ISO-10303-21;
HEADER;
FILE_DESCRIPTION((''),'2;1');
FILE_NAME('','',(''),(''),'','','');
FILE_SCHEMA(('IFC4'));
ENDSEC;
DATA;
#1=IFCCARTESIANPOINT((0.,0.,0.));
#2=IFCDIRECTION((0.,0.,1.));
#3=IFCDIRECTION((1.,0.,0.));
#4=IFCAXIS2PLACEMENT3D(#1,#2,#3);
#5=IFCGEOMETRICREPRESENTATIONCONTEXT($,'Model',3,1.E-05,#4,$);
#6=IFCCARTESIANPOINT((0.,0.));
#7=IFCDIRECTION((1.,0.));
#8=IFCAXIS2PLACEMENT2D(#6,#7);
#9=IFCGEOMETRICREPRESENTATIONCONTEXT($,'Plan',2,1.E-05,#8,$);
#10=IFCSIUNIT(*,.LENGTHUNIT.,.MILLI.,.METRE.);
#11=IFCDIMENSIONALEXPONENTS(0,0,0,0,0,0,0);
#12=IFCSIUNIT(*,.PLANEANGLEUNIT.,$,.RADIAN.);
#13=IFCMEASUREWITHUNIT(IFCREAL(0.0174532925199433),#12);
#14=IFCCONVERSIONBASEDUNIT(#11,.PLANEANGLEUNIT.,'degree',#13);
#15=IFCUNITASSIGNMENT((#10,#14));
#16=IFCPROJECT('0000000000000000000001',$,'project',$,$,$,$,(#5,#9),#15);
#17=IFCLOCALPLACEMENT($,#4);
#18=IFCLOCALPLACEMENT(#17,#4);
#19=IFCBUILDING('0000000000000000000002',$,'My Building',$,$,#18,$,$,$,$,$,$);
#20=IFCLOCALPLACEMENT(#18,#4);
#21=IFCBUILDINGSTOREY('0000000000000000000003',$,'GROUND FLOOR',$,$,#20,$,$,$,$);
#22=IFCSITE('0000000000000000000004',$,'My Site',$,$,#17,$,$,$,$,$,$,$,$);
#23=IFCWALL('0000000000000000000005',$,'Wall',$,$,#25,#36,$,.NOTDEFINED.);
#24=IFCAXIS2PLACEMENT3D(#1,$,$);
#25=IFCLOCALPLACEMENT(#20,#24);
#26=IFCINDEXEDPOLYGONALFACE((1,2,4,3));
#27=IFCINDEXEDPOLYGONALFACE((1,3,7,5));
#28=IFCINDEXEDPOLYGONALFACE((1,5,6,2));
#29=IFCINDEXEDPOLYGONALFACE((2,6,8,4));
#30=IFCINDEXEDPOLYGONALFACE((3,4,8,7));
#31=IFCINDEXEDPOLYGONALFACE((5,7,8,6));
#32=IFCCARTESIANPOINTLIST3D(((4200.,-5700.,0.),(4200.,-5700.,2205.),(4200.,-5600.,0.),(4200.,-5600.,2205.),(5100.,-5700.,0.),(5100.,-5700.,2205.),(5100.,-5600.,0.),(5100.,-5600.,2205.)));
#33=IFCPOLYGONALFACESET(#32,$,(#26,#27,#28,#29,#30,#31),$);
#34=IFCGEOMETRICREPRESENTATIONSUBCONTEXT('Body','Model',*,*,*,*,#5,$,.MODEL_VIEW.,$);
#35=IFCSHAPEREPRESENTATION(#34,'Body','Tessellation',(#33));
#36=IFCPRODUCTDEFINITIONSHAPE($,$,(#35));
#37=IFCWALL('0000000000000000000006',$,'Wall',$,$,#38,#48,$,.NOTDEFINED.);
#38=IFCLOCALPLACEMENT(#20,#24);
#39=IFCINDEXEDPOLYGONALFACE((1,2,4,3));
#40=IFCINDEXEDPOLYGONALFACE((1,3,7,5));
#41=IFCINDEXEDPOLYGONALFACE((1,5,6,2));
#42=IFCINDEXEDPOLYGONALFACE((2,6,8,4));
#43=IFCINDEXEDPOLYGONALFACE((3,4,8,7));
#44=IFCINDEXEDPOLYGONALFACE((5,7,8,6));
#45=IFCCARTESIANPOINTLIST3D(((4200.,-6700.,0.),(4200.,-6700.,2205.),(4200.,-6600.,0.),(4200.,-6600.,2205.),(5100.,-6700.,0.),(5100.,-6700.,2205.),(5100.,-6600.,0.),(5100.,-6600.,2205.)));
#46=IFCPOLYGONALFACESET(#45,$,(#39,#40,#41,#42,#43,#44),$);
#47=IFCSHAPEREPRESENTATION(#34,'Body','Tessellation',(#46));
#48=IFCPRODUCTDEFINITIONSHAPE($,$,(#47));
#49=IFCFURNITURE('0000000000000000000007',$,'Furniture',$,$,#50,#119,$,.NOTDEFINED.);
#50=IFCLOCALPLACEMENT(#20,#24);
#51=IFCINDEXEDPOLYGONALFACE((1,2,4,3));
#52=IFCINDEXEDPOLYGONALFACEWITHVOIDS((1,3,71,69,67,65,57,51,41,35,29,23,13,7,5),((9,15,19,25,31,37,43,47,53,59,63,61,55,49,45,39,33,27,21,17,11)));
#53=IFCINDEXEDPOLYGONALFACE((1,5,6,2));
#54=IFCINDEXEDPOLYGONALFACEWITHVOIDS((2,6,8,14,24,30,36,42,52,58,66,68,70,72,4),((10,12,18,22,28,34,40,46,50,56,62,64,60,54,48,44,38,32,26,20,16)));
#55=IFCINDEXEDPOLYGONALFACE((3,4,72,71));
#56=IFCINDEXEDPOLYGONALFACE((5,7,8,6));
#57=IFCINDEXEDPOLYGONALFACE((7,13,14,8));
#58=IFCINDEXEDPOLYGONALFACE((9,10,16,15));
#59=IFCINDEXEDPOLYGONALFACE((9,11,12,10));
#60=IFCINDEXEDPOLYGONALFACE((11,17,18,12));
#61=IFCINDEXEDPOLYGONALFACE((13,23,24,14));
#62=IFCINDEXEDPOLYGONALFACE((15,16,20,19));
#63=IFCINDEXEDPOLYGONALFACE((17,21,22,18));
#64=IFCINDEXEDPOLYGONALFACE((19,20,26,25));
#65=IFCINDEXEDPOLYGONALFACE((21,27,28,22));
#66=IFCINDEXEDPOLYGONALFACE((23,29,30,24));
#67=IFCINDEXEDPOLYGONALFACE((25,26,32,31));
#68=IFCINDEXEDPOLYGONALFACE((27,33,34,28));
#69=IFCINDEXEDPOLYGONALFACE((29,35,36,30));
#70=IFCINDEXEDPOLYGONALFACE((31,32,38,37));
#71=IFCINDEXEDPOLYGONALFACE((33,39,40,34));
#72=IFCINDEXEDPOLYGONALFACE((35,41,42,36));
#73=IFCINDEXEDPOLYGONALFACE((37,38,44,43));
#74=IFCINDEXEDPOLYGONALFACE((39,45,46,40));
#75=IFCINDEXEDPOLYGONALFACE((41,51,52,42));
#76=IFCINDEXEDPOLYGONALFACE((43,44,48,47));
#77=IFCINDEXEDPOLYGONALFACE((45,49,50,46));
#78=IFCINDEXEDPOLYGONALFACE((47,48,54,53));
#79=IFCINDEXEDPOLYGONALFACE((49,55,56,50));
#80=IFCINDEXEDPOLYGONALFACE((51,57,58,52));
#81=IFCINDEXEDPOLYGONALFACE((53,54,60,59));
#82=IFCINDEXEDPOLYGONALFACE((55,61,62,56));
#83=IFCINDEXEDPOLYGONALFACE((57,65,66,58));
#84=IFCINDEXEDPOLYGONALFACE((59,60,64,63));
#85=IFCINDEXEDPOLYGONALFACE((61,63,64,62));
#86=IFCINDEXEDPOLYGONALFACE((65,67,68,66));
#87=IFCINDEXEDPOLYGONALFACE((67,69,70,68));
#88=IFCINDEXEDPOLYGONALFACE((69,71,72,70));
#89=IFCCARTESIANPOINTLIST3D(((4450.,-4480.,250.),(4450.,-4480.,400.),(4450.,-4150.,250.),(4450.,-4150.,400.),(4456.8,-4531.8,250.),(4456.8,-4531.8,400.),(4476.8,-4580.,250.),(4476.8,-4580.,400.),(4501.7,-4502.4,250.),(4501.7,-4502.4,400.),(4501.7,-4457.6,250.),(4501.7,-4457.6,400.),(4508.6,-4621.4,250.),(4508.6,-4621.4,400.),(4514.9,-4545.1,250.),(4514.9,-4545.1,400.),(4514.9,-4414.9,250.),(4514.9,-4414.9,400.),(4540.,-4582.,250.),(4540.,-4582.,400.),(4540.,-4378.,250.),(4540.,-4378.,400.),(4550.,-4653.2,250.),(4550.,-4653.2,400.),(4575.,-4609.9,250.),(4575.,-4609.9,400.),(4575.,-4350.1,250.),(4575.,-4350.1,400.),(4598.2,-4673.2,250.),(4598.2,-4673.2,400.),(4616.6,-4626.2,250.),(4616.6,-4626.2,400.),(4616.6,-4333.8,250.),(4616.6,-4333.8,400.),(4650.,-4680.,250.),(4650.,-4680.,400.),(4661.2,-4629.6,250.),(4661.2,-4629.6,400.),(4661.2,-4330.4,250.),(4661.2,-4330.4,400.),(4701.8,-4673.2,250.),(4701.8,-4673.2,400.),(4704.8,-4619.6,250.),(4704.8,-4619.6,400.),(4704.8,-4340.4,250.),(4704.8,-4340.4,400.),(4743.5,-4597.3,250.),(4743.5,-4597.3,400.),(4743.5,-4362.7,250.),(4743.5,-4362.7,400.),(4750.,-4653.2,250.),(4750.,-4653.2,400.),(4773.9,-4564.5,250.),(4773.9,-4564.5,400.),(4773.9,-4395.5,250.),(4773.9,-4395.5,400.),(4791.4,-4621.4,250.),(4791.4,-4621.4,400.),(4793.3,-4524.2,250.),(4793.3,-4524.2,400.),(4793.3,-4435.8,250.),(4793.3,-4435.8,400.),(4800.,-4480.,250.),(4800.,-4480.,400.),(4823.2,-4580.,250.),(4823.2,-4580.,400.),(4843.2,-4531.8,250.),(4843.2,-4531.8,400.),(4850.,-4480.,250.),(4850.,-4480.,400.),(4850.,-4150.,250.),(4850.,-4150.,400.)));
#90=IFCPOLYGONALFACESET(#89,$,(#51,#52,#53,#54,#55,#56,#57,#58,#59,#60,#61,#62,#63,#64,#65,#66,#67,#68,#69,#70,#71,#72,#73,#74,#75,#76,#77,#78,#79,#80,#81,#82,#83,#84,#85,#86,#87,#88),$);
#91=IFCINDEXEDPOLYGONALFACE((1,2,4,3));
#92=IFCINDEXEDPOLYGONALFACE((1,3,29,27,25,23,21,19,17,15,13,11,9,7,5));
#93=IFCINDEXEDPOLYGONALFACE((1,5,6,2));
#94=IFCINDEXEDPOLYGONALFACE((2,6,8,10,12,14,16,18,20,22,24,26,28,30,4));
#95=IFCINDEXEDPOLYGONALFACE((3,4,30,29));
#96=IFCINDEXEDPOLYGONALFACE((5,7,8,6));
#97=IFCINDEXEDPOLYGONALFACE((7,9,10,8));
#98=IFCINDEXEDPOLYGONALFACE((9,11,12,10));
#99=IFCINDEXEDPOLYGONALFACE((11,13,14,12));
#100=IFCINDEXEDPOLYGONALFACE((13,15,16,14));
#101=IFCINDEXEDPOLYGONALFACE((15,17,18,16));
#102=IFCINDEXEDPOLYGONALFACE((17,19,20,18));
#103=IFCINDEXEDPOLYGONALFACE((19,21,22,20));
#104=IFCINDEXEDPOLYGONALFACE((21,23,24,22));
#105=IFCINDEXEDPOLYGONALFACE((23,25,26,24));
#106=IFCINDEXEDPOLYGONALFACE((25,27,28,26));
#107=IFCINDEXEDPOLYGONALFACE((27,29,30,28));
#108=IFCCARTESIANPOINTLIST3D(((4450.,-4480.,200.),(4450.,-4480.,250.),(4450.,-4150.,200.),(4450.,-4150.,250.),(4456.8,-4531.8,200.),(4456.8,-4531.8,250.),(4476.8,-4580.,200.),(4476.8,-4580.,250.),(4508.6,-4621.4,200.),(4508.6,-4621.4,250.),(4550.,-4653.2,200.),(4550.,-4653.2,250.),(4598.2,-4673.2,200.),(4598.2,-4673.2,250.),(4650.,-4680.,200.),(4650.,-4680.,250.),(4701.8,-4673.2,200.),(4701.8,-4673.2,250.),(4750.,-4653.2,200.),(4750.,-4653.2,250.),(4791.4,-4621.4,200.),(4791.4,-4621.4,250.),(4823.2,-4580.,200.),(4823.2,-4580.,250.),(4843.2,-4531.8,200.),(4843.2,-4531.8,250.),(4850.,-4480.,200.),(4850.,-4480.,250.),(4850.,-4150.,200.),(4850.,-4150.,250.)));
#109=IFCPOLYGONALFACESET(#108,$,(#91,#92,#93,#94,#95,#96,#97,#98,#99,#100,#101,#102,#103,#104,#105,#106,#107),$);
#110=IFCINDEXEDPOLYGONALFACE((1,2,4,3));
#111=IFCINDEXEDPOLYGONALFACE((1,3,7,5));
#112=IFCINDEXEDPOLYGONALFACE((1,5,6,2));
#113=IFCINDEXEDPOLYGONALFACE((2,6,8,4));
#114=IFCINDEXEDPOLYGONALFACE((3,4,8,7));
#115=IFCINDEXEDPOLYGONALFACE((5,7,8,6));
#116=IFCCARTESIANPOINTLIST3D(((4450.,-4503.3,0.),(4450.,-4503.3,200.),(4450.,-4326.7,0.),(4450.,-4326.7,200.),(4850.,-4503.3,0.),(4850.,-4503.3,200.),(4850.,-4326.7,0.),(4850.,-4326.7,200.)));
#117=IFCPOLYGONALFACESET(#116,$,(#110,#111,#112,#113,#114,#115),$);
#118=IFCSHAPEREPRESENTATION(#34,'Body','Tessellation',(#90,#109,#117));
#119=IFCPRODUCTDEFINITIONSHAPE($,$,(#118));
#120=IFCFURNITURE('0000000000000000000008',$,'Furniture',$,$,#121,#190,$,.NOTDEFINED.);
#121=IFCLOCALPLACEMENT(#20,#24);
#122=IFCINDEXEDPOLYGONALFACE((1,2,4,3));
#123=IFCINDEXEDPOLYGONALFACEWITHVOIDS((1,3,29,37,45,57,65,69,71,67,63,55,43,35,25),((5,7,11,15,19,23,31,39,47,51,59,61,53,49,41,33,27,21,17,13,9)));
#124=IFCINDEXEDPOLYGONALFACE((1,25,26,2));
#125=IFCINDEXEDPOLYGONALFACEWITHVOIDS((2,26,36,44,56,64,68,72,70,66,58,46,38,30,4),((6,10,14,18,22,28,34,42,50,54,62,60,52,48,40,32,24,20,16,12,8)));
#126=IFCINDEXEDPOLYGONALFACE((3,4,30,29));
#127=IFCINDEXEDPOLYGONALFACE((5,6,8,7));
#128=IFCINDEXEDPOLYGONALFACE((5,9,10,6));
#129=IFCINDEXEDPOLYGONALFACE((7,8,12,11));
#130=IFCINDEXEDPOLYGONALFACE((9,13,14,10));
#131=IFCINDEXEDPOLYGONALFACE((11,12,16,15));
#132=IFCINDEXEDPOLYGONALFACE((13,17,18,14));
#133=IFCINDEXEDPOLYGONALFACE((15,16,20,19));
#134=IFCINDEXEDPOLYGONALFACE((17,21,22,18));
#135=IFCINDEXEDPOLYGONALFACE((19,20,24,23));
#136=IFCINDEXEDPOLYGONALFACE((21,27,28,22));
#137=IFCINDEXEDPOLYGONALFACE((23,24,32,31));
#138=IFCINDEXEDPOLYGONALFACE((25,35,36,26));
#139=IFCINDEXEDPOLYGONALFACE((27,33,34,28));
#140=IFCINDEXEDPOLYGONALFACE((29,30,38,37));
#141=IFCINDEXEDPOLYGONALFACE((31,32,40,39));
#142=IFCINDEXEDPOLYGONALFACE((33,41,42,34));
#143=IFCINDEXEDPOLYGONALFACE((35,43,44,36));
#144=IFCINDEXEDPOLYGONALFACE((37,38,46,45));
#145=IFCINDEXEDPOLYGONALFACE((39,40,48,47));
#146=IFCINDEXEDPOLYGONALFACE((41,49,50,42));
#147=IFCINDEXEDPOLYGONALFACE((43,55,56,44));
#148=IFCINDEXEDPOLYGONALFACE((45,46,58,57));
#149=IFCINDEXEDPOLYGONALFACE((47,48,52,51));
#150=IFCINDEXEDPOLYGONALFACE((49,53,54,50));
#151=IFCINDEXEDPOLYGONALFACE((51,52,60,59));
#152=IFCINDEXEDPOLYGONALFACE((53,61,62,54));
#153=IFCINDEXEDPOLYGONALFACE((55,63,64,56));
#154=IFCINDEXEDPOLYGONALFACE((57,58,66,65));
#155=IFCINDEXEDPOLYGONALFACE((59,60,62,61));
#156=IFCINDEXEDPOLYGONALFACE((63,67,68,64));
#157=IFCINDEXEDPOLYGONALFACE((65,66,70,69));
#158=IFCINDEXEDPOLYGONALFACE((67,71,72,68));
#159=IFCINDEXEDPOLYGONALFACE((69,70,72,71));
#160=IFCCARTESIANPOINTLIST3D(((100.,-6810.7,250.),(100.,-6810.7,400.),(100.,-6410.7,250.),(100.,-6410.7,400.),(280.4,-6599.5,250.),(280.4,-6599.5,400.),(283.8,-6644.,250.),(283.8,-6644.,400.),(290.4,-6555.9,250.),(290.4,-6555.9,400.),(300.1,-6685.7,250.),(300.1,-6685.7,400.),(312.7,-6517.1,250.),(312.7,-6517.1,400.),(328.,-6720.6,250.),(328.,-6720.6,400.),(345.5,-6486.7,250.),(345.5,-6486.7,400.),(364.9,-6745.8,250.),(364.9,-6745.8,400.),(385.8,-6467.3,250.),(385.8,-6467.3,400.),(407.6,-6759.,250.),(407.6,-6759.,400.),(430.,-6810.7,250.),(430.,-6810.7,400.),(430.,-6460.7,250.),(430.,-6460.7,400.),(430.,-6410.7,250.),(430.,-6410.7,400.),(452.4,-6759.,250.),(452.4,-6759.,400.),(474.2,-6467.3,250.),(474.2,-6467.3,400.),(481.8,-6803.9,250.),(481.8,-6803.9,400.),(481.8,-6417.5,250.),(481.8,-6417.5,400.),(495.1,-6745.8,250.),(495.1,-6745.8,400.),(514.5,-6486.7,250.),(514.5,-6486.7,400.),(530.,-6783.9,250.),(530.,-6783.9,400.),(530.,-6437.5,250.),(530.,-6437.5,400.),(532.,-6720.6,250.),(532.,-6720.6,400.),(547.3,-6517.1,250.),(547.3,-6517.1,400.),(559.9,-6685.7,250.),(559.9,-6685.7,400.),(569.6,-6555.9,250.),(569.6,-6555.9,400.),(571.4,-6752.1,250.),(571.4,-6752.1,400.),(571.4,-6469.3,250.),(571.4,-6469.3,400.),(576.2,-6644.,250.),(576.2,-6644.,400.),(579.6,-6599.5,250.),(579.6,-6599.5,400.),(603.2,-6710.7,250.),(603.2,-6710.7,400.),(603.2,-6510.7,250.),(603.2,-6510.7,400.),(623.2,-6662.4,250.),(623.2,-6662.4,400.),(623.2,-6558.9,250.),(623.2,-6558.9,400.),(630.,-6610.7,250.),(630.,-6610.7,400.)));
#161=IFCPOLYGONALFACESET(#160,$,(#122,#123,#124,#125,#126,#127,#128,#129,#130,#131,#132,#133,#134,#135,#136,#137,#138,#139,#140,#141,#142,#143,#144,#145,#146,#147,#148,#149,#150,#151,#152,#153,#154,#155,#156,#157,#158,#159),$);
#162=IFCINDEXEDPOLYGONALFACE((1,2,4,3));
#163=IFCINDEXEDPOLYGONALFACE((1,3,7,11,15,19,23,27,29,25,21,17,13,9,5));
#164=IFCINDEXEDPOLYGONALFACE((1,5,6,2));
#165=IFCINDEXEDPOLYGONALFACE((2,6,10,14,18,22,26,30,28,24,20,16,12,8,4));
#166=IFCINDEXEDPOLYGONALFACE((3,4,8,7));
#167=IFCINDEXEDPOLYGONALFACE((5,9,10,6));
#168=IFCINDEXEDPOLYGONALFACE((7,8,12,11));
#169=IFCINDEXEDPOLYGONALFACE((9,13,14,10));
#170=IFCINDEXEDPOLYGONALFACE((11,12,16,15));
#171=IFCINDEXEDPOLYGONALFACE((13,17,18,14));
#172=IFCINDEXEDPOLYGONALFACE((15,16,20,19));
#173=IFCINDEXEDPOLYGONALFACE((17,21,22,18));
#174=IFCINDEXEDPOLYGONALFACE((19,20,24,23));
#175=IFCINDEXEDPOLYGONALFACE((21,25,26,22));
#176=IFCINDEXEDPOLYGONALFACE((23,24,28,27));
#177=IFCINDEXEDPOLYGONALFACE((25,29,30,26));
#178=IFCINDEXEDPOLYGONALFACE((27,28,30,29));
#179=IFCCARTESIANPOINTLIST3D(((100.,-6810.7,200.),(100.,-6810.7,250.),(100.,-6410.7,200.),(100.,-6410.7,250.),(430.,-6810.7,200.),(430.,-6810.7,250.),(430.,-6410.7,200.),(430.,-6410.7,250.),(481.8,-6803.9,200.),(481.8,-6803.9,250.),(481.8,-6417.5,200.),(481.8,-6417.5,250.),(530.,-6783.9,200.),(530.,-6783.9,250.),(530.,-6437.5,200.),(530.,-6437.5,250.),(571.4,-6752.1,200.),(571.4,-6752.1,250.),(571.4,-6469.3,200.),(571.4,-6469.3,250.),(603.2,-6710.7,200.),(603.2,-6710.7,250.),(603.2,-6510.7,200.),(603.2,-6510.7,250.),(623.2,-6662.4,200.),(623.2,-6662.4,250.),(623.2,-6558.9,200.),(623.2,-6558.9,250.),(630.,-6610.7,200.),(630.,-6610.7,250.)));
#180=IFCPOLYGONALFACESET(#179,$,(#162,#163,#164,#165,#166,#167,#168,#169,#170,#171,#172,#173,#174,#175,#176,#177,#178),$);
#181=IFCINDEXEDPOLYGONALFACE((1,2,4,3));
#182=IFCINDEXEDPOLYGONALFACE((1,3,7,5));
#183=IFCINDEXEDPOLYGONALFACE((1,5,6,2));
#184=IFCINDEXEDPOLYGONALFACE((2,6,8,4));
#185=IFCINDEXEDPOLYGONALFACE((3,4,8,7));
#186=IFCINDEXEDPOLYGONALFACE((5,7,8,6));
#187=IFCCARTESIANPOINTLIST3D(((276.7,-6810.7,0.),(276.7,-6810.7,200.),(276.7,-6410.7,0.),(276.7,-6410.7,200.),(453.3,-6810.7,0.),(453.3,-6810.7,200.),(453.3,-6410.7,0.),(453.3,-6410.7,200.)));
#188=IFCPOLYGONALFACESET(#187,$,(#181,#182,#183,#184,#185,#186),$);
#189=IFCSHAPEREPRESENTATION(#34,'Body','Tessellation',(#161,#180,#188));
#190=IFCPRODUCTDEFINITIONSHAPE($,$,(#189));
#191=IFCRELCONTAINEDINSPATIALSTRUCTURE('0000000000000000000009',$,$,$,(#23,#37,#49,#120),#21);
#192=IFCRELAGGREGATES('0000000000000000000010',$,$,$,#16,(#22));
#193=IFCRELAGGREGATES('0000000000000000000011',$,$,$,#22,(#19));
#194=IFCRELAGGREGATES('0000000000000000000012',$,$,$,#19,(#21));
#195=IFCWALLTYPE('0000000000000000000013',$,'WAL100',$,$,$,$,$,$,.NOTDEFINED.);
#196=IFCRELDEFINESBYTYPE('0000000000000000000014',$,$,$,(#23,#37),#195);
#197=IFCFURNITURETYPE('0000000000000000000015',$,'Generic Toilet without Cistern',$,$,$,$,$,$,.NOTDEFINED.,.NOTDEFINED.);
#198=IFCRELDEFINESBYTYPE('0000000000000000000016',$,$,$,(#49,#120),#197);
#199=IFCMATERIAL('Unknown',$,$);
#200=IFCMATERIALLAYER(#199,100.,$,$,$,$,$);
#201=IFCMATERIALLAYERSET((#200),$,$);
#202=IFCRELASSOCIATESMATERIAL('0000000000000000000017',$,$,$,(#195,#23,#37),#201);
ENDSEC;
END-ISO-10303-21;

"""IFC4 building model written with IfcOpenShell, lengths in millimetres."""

from ifc_helpers import new_model, entity, si_unit, converted_unit, frame, frame_2d, origin_with_axes, origin_2d_with_axis, place, context, subcontext, project, spatial, line, arc, indexed_curve, circle_curve, outline, extrude, source, transform, mapped, material, layer, layer_set, layer_usage, type_object, type_shapes, element, save


model = new_model("IFC4")

# Units and contexts
model_context = context("Model", 3, precision=1e-05, world=origin_with_axes())
plan_context = context("Plan", 2, precision=1e-05, world=origin_2d_with_axis())
body_context = subcontext(model_context, "Body", "Model", "MODEL_VIEW")
ifc_project = project(units=[si_unit("LENGTHUNIT", "METRE", prefix="MILLI"), converted_unit("PLANEANGLEUNIT", "degree", entity("IfcReal", 0.0174532925199433), si_unit("PLANEANGLEUNIT", "RADIAN"), dimensions=[0, 0, 0, 0, 0, 0, 0])], contexts=[model_context, plan_context])

# Site, building, storey
site_placement = place(None, origin_with_axes())
site = spatial("IfcSite", under=ifc_project, at=site_placement, Name="My Site")
building_placement = place(site_placement, origin_with_axes())
building = spatial("IfcBuilding", under=site, at=building_placement, Name="My Building")
storey_placement = place(building_placement, origin_with_axes())
storey = spatial("IfcBuildingStorey", under=building, at=storey_placement, Name="GROUND FLOOR")

# Shared definitions
ifc_material = material(Name="Unknown")

# Walls
ifc_layer_1 = layer(ifc_material, 100.0)
ifc_layer_set_1 = layer_set([ifc_layer_1])
wall_type = type_object("IfcWallType", Name="WAL100", PredefinedType="NOTDEFINED", material=ifc_layer_set_1)
ifc_layer_usage_1 = layer_usage(ifc_layer_set_1, "AXIS2", "POSITIVE", 0.0)
wall_1_placement = place(storey_placement, frame((5100.0, -5600.0, 0.0), z_axis=(0.0, 0.0, 1.0), x_axis=(-1.0, 0.0, 0.0)))
element("IfcWall", 1, at=wall_1_placement, inside=storey, type_object=wall_type, material=ifc_layer_usage_1, Name="Wall", PredefinedType="NOTDEFINED", context=body_context, shape_type="SweptSolid", body=[
    extrude(outline(indexed_curve([(0.0, 0.0), (0.0, 100.0), (900.0, 100.0), (900.0, 0.0), (0.0, 0.0)], self_intersect=False)), origin_with_axes(), (0.0, 0.0, 1.0), 2205.0),
])
ifc_layer_usage_2 = layer_usage(ifc_layer_set_1, "AXIS2", "POSITIVE", 0.0)
wall_2_placement = place(storey_placement, frame((5100.0, -6600.0, 0.0), z_axis=(0.0, 0.0, 1.0), x_axis=(-1.0, 0.0, 0.0)))
element("IfcWall", 2, at=wall_2_placement, inside=storey, type_object=wall_type, material=ifc_layer_usage_2, Name="Wall", PredefinedType="NOTDEFINED", context=body_context, shape_type="SweptSolid", body=[
    extrude(outline(indexed_curve([(0.0, 0.0), (0.0, 100.0), (900.0, 100.0), (900.0, 0.0), (0.0, 0.0)], self_intersect=False)), origin_with_axes(), (0.0, 0.0, 1.0), 2205.0),
])

# Furniture
furniture_type_1 = type_object("IfcFurnitureType", Name="Generic Toilet without Cistern", AssemblyPlace="NOTDEFINED", PredefinedType="NOTDEFINED")
shared_shape_1 = source(origin_with_axes(), body_context, "Body", "SweptSolid", [
    extrude(outline(indexed_curve([(-200.0, 0.0, 0.0), (-200.0, -330.0, 0.0), (-141.4, -471.4, 0.0), (0.0, -530.0, 0.0), (141.4, -471.4, 0.0), (200.0, -330.0, 0.0), (200.0, 0.0, 0.0)], segments=[line(1, 2), arc(2, 3, 4), arc(4, 5, 6), line(6, 7), line(1, 7)]), holes=[circle_curve(frame_2d((0.0, -330.0)), 150.0)]), frame((0.0, 0.0, 250.0), z_axis=(0.0, 0.0, 1.0), x_axis=(1.0, 0.0, 0.0)), (0.0, 0.0, 1.0), 150.0),
    extrude(outline(indexed_curve([(-200.0, 0.0, 0.0), (-200.0, -330.0, 0.0), (-141.4, -471.4, 0.0), (0.0, -530.0, 0.0), (141.4, -471.4, 0.0), (200.0, -330.0, 0.0), (200.0, 0.0, 0.0)], segments=[line(1, 2), arc(2, 3, 4), arc(4, 5, 6), line(6, 7), line(1, 7)])), frame((0.0, 0.0, 200.0), z_axis=(0.0, 0.0, 1.0), x_axis=(1.0, 0.0, 0.0)), (0.0, 0.0, 1.0), 50.0),
    extrude(outline(indexed_curve([(-200.0, -176.7, 0.0), (-200.0, -353.3, 0.0), (200.0, -353.3, 0.0), (200.0, -176.7, 0.0)], segments=[line(1, 2), line(2, 3), line(3, 4), line(4, 1)])), origin_with_axes(), (0.0, 0.0, 1.0), 200.0),
])
type_shapes(furniture_type_1, [shared_shape_1])
for number, where, z_axis, x_axis, name in (
    (3, (4650.0, -4150.0, 0.0), (0.0, 0.0, 1.0), (1.0, 0.0, 0.0), "Furniture"),
    (4, (100.0, -6610.7, 0.0), (0.0, 0.0, 1.0), (0.0, 1.0, 0.0), "Furniture"),
):
    element("IfcFurniture", number, at=place(storey_placement, frame(where, z_axis=z_axis, x_axis=x_axis)), inside=storey, type_object=furniture_type_1, Name=name, PredefinedType="NOTDEFINED", context=body_context, shape_type="MappedRepresentation", body=[
        mapped(shared_shape_1, transform((0.0, 0.0, 0.0), x_axis=(1.0, 0.0, 0.0), y_axis=(0.0, 1.0, 0.0), z_axis=(0.0, 0.0, 1.0), scale=1.0)),
    ])

save(model, "model.ifc")
